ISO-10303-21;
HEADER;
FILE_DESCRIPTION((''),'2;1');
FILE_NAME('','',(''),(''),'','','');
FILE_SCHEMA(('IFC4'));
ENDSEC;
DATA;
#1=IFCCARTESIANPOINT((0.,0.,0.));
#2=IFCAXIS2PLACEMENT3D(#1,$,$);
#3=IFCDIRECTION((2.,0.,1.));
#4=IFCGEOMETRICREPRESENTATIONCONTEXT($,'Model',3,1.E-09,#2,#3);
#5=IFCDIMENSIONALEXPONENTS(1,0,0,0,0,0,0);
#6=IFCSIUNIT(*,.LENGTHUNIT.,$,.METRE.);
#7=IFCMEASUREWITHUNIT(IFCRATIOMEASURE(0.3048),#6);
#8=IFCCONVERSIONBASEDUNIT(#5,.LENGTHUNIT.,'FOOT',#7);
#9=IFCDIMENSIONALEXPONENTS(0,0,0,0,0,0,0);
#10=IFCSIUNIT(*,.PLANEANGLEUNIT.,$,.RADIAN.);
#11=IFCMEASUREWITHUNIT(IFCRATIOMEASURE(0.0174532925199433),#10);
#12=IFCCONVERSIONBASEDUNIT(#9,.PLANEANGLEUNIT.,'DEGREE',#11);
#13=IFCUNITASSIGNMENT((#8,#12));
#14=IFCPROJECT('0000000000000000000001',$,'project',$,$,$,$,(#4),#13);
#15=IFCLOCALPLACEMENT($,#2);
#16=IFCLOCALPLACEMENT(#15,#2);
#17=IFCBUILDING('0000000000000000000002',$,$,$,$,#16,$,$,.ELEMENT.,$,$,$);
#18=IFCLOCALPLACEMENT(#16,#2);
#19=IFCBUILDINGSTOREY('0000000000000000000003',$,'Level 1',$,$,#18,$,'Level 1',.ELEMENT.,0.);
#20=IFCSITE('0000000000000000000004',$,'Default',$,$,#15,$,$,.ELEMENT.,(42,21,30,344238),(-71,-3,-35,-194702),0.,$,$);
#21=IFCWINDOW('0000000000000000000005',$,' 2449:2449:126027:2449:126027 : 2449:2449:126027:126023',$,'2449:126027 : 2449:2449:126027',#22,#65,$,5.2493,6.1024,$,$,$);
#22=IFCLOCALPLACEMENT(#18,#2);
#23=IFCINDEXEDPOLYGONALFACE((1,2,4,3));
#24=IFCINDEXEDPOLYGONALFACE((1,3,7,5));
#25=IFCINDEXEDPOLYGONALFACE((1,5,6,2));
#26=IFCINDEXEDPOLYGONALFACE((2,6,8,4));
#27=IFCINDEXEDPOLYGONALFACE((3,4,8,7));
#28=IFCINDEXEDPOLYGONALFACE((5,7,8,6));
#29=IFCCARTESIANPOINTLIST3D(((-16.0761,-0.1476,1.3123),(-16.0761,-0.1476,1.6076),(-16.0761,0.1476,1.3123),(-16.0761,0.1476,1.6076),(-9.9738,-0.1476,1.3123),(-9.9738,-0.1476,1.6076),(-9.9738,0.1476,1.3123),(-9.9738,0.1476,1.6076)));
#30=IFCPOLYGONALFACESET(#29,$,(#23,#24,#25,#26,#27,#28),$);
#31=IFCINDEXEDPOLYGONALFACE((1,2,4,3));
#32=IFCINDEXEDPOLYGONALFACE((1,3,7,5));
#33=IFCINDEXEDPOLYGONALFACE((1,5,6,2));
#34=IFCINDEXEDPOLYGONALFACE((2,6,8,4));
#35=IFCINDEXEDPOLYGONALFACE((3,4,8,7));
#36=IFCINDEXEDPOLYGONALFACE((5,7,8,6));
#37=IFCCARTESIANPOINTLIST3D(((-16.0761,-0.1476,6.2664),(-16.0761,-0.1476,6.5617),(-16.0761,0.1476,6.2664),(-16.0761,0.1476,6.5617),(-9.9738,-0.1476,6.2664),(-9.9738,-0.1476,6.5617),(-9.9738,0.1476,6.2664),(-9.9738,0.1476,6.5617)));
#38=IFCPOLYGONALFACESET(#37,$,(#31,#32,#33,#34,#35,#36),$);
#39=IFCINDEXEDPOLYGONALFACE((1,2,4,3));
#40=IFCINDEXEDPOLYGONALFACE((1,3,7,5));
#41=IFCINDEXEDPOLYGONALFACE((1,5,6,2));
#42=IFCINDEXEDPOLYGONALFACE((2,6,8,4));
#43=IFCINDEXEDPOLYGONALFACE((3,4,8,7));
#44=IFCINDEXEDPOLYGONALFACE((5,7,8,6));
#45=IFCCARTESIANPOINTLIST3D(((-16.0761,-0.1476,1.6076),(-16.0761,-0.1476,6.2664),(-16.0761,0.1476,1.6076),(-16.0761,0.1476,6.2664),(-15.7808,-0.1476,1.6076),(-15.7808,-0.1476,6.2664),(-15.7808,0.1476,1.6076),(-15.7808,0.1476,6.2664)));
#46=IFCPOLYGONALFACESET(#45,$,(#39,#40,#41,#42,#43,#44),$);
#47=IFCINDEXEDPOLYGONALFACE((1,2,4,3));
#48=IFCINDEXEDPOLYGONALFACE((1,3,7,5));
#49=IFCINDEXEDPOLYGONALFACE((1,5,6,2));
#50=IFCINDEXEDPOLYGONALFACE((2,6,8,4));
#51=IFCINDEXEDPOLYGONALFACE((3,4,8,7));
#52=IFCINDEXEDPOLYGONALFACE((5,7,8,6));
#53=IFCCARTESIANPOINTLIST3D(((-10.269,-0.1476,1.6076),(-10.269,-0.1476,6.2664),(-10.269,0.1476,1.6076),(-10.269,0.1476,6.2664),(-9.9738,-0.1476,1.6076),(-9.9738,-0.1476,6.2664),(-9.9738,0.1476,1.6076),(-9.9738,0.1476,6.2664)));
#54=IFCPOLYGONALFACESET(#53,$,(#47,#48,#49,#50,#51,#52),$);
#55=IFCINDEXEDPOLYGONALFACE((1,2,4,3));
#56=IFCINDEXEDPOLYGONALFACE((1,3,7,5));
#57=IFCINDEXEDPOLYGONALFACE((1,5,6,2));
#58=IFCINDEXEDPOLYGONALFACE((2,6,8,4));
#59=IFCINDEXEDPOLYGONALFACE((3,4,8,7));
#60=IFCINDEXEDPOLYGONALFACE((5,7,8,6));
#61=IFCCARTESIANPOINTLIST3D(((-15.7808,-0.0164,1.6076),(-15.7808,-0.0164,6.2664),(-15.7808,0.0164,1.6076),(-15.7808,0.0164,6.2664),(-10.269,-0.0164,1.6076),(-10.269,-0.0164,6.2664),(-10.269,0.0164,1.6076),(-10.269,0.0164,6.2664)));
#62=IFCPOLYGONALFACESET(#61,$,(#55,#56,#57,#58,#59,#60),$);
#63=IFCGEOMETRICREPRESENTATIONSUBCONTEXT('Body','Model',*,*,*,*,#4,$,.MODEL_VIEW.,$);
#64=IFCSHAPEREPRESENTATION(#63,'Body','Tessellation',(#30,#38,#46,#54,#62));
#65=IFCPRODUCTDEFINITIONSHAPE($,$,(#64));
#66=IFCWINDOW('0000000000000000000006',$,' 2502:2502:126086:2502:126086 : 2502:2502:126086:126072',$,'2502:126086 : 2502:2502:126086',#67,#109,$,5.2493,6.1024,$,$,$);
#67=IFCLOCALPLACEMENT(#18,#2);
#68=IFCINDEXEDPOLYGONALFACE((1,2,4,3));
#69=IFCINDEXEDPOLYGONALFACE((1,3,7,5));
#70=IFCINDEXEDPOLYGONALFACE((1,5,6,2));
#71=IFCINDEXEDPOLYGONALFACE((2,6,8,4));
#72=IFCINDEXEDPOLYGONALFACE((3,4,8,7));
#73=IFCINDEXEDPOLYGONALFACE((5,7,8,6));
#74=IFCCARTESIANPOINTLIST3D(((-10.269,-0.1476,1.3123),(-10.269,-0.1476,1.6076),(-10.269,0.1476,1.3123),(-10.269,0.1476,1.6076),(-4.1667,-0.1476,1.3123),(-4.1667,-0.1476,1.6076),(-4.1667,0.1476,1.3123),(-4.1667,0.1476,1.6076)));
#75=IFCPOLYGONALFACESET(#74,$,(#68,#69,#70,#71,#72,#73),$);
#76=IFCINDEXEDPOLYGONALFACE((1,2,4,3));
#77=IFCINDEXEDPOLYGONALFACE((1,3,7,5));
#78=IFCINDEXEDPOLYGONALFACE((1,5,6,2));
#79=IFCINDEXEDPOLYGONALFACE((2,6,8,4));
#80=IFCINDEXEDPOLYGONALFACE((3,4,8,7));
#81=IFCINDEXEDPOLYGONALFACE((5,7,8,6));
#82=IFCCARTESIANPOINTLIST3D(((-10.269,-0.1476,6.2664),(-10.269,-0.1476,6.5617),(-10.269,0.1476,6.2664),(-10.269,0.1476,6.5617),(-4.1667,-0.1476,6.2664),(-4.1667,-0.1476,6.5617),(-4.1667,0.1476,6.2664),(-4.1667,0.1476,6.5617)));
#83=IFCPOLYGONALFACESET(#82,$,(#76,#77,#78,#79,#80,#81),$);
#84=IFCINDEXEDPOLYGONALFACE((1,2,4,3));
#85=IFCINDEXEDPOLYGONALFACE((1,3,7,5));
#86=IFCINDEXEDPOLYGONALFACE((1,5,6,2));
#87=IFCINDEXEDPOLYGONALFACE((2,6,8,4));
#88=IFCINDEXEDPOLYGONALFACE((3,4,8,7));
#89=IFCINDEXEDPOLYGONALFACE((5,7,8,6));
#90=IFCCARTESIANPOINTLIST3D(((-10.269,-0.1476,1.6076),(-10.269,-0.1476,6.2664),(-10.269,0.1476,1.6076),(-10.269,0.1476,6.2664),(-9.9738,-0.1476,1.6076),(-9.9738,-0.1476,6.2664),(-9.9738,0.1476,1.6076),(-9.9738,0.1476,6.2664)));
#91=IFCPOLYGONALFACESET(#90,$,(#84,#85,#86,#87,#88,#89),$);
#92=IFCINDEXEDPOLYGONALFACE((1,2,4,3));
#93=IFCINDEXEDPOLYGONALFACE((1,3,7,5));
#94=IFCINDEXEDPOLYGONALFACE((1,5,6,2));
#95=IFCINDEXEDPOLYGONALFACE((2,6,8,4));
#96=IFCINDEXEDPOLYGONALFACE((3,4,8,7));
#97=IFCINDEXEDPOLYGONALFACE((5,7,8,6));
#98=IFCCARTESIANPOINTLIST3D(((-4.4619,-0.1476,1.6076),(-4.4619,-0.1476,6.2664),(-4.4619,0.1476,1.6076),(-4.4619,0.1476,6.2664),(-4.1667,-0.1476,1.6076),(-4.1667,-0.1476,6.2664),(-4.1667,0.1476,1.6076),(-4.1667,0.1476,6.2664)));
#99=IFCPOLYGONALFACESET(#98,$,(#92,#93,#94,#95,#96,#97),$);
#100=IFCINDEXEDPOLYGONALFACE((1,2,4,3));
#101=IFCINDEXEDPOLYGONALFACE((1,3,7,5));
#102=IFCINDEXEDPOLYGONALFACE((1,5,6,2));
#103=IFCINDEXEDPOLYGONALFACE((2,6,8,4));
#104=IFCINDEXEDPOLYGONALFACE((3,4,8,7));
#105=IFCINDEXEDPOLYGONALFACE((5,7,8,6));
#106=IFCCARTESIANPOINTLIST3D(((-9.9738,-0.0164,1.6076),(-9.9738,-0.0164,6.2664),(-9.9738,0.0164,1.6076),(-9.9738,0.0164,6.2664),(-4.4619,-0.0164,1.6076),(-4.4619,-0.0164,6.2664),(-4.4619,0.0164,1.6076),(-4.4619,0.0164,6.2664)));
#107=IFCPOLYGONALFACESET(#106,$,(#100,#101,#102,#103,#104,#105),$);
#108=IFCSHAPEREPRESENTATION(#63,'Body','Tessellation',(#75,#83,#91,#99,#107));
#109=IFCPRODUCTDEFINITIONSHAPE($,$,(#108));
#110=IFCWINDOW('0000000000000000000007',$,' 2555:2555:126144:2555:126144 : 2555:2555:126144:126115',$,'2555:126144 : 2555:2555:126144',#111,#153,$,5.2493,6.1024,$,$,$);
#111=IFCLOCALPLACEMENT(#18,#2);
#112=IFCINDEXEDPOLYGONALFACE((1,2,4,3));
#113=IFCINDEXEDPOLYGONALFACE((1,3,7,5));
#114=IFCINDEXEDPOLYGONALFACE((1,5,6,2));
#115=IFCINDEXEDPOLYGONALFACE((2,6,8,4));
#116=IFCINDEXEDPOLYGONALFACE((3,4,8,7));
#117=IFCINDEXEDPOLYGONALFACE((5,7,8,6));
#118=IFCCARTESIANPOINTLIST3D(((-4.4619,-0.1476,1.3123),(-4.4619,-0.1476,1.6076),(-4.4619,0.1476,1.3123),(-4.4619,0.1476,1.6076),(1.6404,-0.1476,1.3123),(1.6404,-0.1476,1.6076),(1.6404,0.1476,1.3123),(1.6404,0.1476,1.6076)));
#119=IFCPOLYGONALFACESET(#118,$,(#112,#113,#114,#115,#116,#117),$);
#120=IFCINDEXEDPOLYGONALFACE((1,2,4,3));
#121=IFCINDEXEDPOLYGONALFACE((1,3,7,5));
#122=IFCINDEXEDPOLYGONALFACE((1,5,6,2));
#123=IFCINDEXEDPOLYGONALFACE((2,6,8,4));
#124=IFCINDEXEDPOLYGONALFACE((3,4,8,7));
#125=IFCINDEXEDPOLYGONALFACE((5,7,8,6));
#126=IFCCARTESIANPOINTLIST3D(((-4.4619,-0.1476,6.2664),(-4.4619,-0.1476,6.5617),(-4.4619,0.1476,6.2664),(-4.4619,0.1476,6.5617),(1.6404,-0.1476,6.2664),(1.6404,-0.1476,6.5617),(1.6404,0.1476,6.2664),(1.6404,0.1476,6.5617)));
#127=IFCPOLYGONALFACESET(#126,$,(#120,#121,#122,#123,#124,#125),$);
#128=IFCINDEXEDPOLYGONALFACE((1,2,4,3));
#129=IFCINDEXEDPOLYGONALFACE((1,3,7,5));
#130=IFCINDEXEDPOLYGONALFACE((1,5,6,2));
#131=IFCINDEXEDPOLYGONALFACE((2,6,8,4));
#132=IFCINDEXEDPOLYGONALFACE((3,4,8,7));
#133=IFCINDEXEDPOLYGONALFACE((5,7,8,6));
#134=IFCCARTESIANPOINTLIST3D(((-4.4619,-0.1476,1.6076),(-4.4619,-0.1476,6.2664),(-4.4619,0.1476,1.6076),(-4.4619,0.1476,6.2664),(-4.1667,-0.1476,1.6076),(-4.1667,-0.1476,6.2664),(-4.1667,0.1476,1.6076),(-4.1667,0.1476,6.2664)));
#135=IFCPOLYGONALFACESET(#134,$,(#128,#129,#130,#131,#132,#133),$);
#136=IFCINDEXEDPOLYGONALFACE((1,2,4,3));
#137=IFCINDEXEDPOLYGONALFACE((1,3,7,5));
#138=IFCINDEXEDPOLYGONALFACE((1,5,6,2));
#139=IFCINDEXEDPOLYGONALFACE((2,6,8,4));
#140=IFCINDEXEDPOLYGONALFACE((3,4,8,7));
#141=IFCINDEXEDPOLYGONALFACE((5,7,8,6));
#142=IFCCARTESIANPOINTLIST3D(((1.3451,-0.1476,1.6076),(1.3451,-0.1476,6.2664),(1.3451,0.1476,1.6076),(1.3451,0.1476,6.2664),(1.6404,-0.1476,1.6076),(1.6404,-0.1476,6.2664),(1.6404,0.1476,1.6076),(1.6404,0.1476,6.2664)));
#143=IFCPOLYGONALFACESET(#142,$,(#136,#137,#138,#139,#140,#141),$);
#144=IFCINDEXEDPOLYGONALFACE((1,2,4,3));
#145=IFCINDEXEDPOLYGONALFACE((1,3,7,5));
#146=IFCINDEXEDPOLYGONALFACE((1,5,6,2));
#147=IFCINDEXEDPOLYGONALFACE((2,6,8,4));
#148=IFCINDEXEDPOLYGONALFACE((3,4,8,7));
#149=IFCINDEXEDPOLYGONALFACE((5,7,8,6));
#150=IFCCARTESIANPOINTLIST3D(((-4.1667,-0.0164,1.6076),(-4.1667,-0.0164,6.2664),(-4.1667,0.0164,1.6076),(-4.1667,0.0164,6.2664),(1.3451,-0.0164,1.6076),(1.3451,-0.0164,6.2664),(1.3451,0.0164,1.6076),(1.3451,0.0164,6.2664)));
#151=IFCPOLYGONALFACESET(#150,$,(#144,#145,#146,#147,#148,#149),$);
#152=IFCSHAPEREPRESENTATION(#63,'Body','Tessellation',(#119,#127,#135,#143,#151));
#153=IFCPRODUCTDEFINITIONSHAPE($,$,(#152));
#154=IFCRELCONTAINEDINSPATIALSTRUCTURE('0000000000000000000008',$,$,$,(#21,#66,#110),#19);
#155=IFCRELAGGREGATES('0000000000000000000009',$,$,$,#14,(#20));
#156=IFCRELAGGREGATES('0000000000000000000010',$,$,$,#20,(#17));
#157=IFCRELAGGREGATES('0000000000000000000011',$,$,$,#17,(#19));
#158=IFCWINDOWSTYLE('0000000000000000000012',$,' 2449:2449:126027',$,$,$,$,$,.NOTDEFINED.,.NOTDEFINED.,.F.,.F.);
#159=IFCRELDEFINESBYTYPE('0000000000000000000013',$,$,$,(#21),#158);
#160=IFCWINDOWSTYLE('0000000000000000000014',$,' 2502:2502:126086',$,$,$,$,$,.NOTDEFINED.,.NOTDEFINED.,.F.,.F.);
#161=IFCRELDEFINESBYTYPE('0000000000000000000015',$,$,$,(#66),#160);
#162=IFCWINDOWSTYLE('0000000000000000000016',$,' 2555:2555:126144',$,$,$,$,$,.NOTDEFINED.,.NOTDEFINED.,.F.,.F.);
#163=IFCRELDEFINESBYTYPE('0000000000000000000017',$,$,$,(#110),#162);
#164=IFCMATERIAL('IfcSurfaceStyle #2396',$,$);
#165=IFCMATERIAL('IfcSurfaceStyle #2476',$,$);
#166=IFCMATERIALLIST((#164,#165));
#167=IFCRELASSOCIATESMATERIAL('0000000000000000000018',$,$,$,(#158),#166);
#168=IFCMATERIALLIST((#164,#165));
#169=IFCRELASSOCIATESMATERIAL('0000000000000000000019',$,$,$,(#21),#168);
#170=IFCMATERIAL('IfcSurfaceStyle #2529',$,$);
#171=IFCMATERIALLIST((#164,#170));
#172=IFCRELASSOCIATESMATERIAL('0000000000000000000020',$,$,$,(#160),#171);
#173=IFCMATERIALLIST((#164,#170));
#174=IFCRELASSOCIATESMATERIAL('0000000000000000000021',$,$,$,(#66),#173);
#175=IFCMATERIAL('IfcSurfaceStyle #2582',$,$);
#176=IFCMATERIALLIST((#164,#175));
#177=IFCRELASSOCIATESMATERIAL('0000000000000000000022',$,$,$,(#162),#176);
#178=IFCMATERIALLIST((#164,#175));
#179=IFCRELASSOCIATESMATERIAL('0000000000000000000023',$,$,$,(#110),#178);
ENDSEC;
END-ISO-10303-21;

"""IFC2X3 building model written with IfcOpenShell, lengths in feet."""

from ifc_helpers import new_model, entity, si_unit, converted_unit, direction, frame, frame_2d, origin, origin_2d_with_axis, place, context, subcontext, project, spatial, rectangle, extrude, source, transform, mapped, material, material_list, type_object, type_shapes, element, save


model = new_model("IFC2X3")

# Units and contexts
model_context = context("Model", 3, precision=1e-09, world=origin(), true_north=direction((2.0, 0.0, 1.0)))
body_context = subcontext(model_context, "Body", "Model", "MODEL_VIEW")
ifc_project = project(units=[converted_unit("LENGTHUNIT", "FOOT", entity("IfcRatioMeasure", 0.3048), si_unit("LENGTHUNIT", "METRE"), dimensions=[1, 0, 0, 0, 0, 0, 0]), converted_unit("PLANEANGLEUNIT", "DEGREE", entity("IfcRatioMeasure", 0.0174532925199433), si_unit("PLANEANGLEUNIT", "RADIAN"), dimensions=[0, 0, 0, 0, 0, 0, 0])], contexts=[model_context])

# Site, building, storey
site_placement = place(None, origin())
site = spatial("IfcSite", under=ifc_project, at=site_placement, Name="Default", CompositionType="ELEMENT", RefLatitude=(42, 21, 30, 344238), RefLongitude=(-71, -3, -35, -194702), RefElevation=0.0)
building_placement = place(site_placement, origin())
building = spatial("IfcBuilding", under=site, at=building_placement, CompositionType="ELEMENT")
storey_placement = place(building_placement, origin())
storey = spatial("IfcBuildingStorey", under=building, at=storey_placement, Name="Level 1", LongName="Level 1", CompositionType="ELEMENT", Elevation=0.0)

# Windows
ifc_material_1 = material(Name="IfcSurfaceStyle #2396")
ifc_material_2 = material(Name="IfcSurfaceStyle #2476")
ifc_material_list_1 = material_list([ifc_material_1, ifc_material_2])
ifc_material_list_2 = material_list([ifc_material_1, ifc_material_2])
window_style_1 = type_object("IfcWindowStyle", Name=" 2449:2449:126027", ConstructionType="NOTDEFINED", OperationType="NOTDEFINED", ParameterTakesPrecedence=False, Sizeable=False, material=ifc_material_list_2)
shared_shape_1 = source(origin(), body_context, "Body", "SweptSolid", [
    extrude(rectangle(XDim=6.1024, YDim=0.2953, at=frame_2d((0.0, 0.0), x_axis=(1.0, 0.0))), frame((-13.0249, 0.0, 1.3123), z_axis=(0.0, 0.0, 1.0), x_axis=(-1.0, 0.0, 0.0)), (0.0, 0.0, 1.0), 0.2953),
    extrude(rectangle(XDim=6.1024, YDim=0.2953, at=frame_2d((0.0, 0.0), x_axis=(1.0, 0.0))), frame((-13.0249, 0.0, 6.2664), z_axis=(0.0, 0.0, 1.0), x_axis=(-1.0, 0.0, 0.0)), (0.0, 0.0, 1.0), 0.2953),
    extrude(rectangle(XDim=0.2953, YDim=0.2953, at=origin_2d_with_axis()), frame((-15.9285, 0.0, 1.6076), z_axis=(0.0, 0.0, 1.0), x_axis=(-1.0, 0.0, 0.0)), (0.0, 0.0, 1.0), 4.6588),
    extrude(rectangle(XDim=0.2953, YDim=0.2953, at=frame_2d((0.0, 0.0), x_axis=(1.0, 0.0))), frame((-10.1214, 0.0, 1.6076), z_axis=(0.0, 0.0, 1.0), x_axis=(-1.0, 0.0, 0.0)), (0.0, 0.0, 1.0), 4.6588),
    extrude(rectangle(XDim=5.5118, YDim=0.0328, at=frame_2d((0.0, 0.0), x_axis=(1.0, 0.0))), frame((-13.0249, 0.0, 1.6076), z_axis=(0.0, 0.0, 1.0), x_axis=(-1.0, 0.0, 0.0)), (0.0, 0.0, 1.0), 4.6588),
])
type_shapes(window_style_1, [shared_shape_1])
window_1_placement = place(storey_placement, origin())
element("IfcWindow", 1, at=window_1_placement, inside=storey, type_object=window_style_1, material=ifc_material_list_1, Name=" 2449:2449:126027:2449:126027 : 2449:2449:126027:126023", ObjectType="2449:126027 : 2449:2449:126027", OverallHeight=5.2493, OverallWidth=6.1024, context=body_context, shape_type="MappedRepresentation", body=[
    mapped(shared_shape_1, transform((0.0, 0.0, 0.0), scale=1.0)),
])
ifc_material_3 = material(Name="IfcSurfaceStyle #2529")
ifc_material_list_3 = material_list([ifc_material_1, ifc_material_3])
ifc_material_list_4 = material_list([ifc_material_1, ifc_material_3])
window_style_2 = type_object("IfcWindowStyle", Name=" 2502:2502:126086", ConstructionType="NOTDEFINED", OperationType="NOTDEFINED", ParameterTakesPrecedence=False, Sizeable=False, material=ifc_material_list_4)
shared_shape_2 = source(origin(), body_context, "Body", "SweptSolid", [
    extrude(rectangle(XDim=6.1024, YDim=0.2953, at=frame_2d((0.0, 0.0), x_axis=(1.0, 0.0))), frame((-7.2178, 0.0, 1.3123), z_axis=(0.0, 0.0, 1.0), x_axis=(-1.0, 0.0, 0.0)), (0.0, 0.0, 1.0), 0.2953),
    extrude(rectangle(XDim=6.1024, YDim=0.2953, at=frame_2d((0.0, 0.0), x_axis=(1.0, 0.0))), frame((-7.2178, 0.0, 6.2664), z_axis=(0.0, 0.0, 1.0), x_axis=(-1.0, 0.0, 0.0)), (0.0, 0.0, 1.0), 0.2953),
    extrude(rectangle(XDim=0.2953, YDim=0.2953, at=frame_2d((0.0, 0.0), x_axis=(1.0, 0.0))), frame((-10.1214, 0.0, 1.6076), z_axis=(0.0, 0.0, 1.0), x_axis=(-1.0, 0.0, 0.0)), (0.0, 0.0, 1.0), 4.6588),
    extrude(rectangle(XDim=0.2953, YDim=0.2953, at=frame_2d((0.0, 0.0), x_axis=(1.0, 0.0))), frame((-4.3143, 0.0, 1.6076), z_axis=(0.0, 0.0, 1.0), x_axis=(-1.0, 0.0, 0.0)), (0.0, 0.0, 1.0), 4.6588),
    extrude(rectangle(XDim=5.5118, YDim=0.0328, at=origin_2d_with_axis()), frame((-7.2178, 0.0, 1.6076), z_axis=(0.0, 0.0, 1.0), x_axis=(-1.0, 0.0, 0.0)), (0.0, 0.0, 1.0), 4.6588),
])
type_shapes(window_style_2, [shared_shape_2])
window_2_placement = place(storey_placement, origin())
element("IfcWindow", 2, at=window_2_placement, inside=storey, type_object=window_style_2, material=ifc_material_list_3, Name=" 2502:2502:126086:2502:126086 : 2502:2502:126086:126072", ObjectType="2502:126086 : 2502:2502:126086", OverallHeight=5.2493, OverallWidth=6.1024, context=body_context, shape_type="MappedRepresentation", body=[
    mapped(shared_shape_2, transform((0.0, 0.0, 0.0), scale=1.0)),
])
ifc_material_4 = material(Name="IfcSurfaceStyle #2582")
ifc_material_list_5 = material_list([ifc_material_1, ifc_material_4])
ifc_material_list_6 = material_list([ifc_material_1, ifc_material_4])
window_style_3 = type_object("IfcWindowStyle", Name=" 2555:2555:126144", ConstructionType="NOTDEFINED", OperationType="NOTDEFINED", ParameterTakesPrecedence=False, Sizeable=False, material=ifc_material_list_6)
shared_shape_3 = source(origin(), body_context, "Body", "SweptSolid", [
    extrude(rectangle(XDim=6.1024, YDim=0.2953, at=origin_2d_with_axis()), frame((-1.4108, 0.0, 1.3123), z_axis=(0.0, 0.0, 1.0), x_axis=(-1.0, 0.0, 0.0)), (0.0, 0.0, 1.0), 0.2953),
    extrude(rectangle(XDim=6.1024, YDim=0.2953, at=origin_2d_with_axis()), frame((-1.4108, 0.0, 6.2664), z_axis=(0.0, 0.0, 1.0), x_axis=(-1.0, 0.0, 0.0)), (0.0, 0.0, 1.0), 0.2953),
    extrude(rectangle(XDim=0.2953, YDim=0.2953, at=frame_2d((0.0, 0.0), x_axis=(1.0, 0.0))), frame((-4.3143, 0.0, 1.6076), z_axis=(0.0, 0.0, 1.0), x_axis=(-1.0, 0.0, 0.0)), (0.0, 0.0, 1.0), 4.6588),
    extrude(rectangle(XDim=0.2953, YDim=0.2953, at=origin_2d_with_axis()), frame((1.4928, 0.0, 1.6076), z_axis=(0.0, 0.0, 1.0), x_axis=(-1.0, 0.0, 0.0)), (0.0, 0.0, 1.0), 4.6588),
    extrude(rectangle(XDim=5.5118, YDim=0.0328, at=frame_2d((0.0, 0.0), x_axis=(1.0, 0.0))), frame((-1.4108, 0.0, 1.6076), z_axis=(0.0, 0.0, 1.0), x_axis=(-1.0, 0.0, 0.0)), (0.0, 0.0, 1.0), 4.6588),
])
type_shapes(window_style_3, [shared_shape_3])
window_3_placement = place(storey_placement, origin())
element("IfcWindow", 3, at=window_3_placement, inside=storey, type_object=window_style_3, material=ifc_material_list_5, Name=" 2555:2555:126144:2555:126144 : 2555:2555:126144:126115", ObjectType="2555:126144 : 2555:2555:126144", OverallHeight=5.2493, OverallWidth=6.1024, context=body_context, shape_type="MappedRepresentation", body=[
    mapped(shared_shape_3, transform((0.0, 0.0, 0.0), scale=1.0)),
])

save(model, "model.ifc")
